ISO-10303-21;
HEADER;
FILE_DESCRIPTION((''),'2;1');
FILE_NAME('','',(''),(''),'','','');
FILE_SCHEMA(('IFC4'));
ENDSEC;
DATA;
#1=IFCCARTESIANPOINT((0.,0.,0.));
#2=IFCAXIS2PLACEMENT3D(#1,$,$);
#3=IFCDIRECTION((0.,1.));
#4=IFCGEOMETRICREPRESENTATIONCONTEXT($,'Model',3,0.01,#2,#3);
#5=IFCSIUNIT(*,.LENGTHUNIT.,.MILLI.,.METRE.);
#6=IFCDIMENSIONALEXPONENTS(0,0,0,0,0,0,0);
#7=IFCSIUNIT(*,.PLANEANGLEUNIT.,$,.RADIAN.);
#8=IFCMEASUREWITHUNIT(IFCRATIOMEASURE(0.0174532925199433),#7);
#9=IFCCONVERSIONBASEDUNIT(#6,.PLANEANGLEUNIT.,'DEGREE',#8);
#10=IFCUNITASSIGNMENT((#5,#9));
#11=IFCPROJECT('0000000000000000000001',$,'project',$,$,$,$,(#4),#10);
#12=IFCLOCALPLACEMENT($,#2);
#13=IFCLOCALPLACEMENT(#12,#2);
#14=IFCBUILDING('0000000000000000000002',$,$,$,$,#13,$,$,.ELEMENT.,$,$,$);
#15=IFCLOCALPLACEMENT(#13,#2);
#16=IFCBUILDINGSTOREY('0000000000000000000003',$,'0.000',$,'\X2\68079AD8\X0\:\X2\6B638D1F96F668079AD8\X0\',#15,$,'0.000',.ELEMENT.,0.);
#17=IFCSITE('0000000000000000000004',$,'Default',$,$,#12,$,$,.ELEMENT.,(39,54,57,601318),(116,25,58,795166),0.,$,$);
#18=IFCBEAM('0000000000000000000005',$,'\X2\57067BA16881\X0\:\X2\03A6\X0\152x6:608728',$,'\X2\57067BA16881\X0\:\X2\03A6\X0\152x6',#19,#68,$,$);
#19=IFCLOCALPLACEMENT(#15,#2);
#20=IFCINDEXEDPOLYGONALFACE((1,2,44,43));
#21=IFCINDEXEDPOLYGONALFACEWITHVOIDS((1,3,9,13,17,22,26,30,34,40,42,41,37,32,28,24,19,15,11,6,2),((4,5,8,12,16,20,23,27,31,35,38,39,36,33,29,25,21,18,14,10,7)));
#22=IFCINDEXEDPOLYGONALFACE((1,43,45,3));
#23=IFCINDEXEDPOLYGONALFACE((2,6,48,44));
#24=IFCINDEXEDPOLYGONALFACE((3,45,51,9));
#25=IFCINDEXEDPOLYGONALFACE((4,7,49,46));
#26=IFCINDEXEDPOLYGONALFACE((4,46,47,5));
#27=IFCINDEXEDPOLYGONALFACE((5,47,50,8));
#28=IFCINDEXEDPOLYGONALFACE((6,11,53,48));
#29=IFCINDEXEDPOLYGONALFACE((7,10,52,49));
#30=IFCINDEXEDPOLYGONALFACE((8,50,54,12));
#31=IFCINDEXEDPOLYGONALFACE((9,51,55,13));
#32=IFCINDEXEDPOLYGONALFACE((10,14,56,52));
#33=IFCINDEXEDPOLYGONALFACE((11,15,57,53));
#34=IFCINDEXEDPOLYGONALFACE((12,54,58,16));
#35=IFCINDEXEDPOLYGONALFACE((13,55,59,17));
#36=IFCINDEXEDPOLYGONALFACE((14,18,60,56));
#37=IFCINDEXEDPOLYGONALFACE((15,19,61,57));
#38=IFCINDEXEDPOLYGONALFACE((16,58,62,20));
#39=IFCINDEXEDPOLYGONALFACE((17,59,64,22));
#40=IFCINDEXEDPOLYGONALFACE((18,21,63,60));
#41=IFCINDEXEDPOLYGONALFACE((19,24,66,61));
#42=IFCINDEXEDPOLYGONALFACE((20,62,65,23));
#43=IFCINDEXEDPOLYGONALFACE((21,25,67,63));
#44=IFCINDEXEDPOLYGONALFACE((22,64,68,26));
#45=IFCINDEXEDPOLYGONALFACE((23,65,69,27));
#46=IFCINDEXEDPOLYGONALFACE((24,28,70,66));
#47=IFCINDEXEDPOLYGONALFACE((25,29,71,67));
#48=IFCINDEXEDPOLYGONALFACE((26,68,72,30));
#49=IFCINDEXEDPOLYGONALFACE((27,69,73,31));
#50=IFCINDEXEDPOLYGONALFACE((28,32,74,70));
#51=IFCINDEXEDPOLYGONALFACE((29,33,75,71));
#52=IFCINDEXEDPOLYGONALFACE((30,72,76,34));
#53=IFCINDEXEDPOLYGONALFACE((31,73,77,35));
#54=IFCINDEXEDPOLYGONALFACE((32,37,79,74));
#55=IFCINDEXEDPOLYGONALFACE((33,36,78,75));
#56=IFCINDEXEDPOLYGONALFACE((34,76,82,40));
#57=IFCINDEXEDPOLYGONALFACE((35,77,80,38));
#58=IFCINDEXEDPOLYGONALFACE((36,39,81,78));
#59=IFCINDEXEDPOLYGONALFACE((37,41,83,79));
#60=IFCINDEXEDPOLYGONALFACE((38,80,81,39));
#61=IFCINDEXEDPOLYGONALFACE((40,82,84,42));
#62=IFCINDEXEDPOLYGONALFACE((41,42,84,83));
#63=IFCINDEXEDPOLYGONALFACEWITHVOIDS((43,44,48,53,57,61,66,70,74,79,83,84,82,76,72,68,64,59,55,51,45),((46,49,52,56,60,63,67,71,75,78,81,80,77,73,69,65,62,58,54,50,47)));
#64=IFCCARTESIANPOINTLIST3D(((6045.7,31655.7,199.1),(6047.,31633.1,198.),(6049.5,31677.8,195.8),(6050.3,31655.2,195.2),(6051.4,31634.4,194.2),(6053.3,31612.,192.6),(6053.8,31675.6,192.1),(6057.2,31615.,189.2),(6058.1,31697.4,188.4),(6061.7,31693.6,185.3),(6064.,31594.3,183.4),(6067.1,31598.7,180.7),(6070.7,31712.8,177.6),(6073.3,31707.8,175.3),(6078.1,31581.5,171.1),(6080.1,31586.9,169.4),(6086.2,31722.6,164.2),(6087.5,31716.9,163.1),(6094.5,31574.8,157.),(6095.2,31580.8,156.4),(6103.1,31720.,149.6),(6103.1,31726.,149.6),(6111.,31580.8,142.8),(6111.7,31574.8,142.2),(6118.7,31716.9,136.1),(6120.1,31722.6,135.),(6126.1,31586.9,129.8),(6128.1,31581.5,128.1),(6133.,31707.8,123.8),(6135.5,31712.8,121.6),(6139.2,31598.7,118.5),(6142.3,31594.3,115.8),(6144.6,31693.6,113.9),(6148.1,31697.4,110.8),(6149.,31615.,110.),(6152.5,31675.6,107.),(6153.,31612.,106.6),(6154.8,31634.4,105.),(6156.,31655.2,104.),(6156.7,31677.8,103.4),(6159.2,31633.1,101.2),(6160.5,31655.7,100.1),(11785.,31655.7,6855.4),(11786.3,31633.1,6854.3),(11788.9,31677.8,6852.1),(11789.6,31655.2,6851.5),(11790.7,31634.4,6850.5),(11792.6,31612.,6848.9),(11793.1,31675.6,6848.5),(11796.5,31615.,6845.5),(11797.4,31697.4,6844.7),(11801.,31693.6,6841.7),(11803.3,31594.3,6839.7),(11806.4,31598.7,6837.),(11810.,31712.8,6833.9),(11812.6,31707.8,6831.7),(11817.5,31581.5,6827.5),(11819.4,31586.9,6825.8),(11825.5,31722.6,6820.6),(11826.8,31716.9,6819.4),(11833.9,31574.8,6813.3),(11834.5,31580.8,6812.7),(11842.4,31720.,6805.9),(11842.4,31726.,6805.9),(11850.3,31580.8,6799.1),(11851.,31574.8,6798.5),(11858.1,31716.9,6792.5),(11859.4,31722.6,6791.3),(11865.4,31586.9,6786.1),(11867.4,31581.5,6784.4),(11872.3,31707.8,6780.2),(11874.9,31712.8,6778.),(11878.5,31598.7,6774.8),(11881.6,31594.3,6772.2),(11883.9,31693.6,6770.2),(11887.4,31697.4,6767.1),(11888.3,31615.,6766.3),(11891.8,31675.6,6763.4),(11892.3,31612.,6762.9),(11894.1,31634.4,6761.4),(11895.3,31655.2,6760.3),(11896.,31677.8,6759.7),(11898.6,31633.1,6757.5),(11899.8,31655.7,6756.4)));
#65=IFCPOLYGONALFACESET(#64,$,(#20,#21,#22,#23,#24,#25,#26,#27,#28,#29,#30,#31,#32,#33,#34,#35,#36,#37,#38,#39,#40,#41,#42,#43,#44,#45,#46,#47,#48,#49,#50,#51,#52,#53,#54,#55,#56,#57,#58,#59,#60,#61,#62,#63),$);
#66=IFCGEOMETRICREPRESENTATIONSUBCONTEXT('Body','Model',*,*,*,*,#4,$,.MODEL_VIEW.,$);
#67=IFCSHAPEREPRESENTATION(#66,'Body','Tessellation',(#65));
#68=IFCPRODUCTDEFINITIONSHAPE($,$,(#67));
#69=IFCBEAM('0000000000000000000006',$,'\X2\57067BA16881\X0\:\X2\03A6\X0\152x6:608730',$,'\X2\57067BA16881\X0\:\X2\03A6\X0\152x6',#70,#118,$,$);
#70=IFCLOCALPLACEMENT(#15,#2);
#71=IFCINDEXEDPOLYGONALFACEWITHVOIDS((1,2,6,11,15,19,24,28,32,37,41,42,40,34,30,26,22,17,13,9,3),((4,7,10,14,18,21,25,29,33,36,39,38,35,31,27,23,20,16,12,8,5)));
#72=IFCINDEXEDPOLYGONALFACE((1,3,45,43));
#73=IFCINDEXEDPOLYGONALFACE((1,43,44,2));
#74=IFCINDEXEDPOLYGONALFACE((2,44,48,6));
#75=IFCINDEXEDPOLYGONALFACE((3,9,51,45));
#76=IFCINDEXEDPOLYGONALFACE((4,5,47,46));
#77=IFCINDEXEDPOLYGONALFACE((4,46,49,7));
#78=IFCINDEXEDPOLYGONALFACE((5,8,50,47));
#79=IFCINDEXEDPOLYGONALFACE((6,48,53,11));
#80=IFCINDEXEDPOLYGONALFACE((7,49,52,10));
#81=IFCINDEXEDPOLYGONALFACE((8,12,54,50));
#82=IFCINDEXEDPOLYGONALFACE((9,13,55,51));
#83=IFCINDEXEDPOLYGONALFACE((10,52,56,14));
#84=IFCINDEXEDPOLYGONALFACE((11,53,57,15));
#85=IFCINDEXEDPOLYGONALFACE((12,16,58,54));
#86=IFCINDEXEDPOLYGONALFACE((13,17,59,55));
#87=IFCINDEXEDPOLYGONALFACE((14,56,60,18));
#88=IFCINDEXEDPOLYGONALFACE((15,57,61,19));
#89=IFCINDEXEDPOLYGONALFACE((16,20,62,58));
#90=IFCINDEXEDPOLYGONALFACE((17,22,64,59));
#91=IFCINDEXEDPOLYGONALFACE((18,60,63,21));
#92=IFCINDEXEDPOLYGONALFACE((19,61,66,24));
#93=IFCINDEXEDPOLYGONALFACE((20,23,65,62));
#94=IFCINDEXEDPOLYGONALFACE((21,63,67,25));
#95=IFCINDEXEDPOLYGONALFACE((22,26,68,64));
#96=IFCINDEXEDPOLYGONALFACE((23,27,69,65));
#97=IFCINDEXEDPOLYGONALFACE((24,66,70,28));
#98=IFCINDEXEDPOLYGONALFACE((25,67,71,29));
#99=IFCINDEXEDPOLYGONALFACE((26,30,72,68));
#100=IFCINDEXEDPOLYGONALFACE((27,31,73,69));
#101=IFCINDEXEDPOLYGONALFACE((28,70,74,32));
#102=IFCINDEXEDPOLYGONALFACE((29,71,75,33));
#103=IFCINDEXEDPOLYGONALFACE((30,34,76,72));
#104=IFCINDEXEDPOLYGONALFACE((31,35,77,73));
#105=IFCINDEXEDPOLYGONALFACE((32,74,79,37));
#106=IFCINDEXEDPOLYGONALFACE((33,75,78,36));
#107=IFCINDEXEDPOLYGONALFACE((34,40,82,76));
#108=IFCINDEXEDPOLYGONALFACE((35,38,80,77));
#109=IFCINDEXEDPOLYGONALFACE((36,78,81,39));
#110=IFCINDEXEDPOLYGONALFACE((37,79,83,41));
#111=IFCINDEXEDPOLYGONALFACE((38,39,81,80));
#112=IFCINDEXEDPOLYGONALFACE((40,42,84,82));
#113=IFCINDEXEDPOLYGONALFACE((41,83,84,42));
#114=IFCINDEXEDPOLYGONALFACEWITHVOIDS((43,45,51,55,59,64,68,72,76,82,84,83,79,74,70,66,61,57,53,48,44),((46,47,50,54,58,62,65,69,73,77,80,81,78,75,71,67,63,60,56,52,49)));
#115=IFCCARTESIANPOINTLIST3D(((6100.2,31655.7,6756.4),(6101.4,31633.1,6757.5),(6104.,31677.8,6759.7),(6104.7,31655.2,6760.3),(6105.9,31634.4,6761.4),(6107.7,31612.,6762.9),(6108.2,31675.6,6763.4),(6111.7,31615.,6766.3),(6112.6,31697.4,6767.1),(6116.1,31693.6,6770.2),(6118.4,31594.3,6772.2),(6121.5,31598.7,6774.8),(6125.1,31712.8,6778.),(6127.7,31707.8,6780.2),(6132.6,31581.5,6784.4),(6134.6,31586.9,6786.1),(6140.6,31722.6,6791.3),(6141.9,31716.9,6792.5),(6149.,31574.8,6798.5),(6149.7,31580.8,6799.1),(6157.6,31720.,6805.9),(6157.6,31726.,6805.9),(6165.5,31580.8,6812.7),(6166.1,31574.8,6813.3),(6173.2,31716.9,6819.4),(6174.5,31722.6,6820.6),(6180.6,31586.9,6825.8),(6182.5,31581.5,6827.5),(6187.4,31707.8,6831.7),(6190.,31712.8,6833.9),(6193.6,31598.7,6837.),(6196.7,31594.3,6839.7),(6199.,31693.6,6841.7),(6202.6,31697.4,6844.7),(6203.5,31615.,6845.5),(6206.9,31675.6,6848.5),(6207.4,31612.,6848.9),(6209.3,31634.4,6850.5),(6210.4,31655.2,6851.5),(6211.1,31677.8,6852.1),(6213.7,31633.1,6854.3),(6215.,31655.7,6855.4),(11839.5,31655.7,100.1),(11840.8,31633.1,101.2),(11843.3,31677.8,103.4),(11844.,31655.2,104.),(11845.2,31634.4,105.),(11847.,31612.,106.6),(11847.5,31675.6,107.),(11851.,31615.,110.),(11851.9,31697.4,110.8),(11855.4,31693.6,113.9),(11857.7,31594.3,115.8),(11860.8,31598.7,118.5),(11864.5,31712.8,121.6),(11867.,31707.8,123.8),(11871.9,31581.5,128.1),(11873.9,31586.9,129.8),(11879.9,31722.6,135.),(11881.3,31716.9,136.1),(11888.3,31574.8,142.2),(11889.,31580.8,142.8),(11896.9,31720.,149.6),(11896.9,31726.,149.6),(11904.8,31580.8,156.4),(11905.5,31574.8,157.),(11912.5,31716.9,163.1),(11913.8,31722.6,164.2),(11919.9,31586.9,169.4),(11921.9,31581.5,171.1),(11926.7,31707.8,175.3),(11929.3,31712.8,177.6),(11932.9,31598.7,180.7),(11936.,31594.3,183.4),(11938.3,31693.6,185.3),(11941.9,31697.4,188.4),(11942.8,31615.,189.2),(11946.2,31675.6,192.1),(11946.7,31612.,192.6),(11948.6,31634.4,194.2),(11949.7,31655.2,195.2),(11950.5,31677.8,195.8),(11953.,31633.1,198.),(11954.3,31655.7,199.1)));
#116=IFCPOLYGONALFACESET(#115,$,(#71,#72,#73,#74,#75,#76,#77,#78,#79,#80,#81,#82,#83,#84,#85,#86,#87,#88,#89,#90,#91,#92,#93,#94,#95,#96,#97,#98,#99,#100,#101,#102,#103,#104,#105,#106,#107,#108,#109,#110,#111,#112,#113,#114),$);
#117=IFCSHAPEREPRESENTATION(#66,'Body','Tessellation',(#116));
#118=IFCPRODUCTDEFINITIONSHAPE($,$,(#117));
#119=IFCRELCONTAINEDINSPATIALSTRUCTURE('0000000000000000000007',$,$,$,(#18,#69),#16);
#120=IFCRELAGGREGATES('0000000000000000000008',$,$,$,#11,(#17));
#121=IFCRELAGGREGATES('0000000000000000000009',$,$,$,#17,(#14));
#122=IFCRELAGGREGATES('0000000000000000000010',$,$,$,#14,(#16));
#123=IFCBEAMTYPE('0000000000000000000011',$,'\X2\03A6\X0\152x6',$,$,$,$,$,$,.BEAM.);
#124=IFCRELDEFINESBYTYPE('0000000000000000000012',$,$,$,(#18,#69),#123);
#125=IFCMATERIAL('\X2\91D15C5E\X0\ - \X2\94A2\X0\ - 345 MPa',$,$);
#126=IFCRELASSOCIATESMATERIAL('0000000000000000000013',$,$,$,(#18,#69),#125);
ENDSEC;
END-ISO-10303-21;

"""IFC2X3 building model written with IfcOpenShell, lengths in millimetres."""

from ifc_helpers import new_model, entity, si_unit, converted_unit, direction, frame, frame_2d, origin, place, context, subcontext, project, spatial, hollow_circle, extrude, material, type_object, element, save


model = new_model("IFC2X3")

# Units and contexts
model_context = context("Model", 3, precision=0.01, world=origin(), true_north=direction((0.0, 1.0)))
body_context = subcontext(model_context, "Body", "Model", "MODEL_VIEW")
ifc_project = project(units=[si_unit("LENGTHUNIT", "METRE", prefix="MILLI"), converted_unit("PLANEANGLEUNIT", "DEGREE", entity("IfcRatioMeasure", 0.0174532925199433), si_unit("PLANEANGLEUNIT", "RADIAN"), dimensions=[0, 0, 0, 0, 0, 0, 0])], contexts=[model_context])

# Site, building, storey
site_placement = place(None, origin())
site = spatial("IfcSite", under=ifc_project, at=site_placement, Name="Default", CompositionType="ELEMENT", RefLatitude=(39, 54, 57, 601318), RefLongitude=(116, 25, 58, 795166), RefElevation=0.0)
building_placement = place(site_placement, origin())
building = spatial("IfcBuilding", under=site, at=building_placement, CompositionType="ELEMENT")
storey_placement = place(building_placement, origin())
storey = spatial("IfcBuildingStorey", under=building, at=storey_placement, Name="0.000", ObjectType="标高:正负零标高", LongName="0.000", CompositionType="ELEMENT", Elevation=0.0)

# Shared definitions
ifc_material_1 = material(Name="金属 - 钢 - 345 MPa")

# Beams
beam_type_1 = type_object("IfcBeamType", Name="Φ152x6", PredefinedType="BEAM")
beam_1_placement = place(storey_placement, frame((6138.2, 31650.0, -116.0), z_axis=(0.757348, 0.0, -0.653011), x_axis=(0.653011, 0.0, 0.757348)))
element("IfcBeam", 1, at=beam_1_placement, inside=storey, type_object=beam_type_1, material=ifc_material_1, Name="圆管梁:Φ152x6:608728", ObjectType="圆管梁:Φ152x6", context=body_context, shape_type="SweptSolid", body=[
    extrude(hollow_circle(Radius=76.0, WallThickness=6.0, at=frame_2d((0.0, 0.0), x_axis=(1.0, 0.0))), frame((178.3, 0.0, -200.0), z_axis=(1.0, 0.0, 0.0), x_axis=(0.0, -1.0, 0.0)), (0.0, 0.0, 1.0), 8789.0),
])
beam_2_placement = place(storey_placement, frame((11861.8, 31650.0, -116.0), z_axis=(0.757348, 0.0, 0.653011), x_axis=(-0.653011, 0.0, 0.757348)))
element("IfcBeam", 2, at=beam_2_placement, inside=storey, type_object=beam_type_1, material=ifc_material_1, Name="圆管梁:Φ152x6:608730", ObjectType="圆管梁:Φ152x6", context=body_context, shape_type="SweptSolid", body=[
    extrude(hollow_circle(Radius=76.0, WallThickness=6.0, at=frame_2d((0.0, 0.0), x_axis=(1.0, 0.0))), frame((178.3, 0.0, 200.0), z_axis=(1.0, 0.0, 0.0), x_axis=(0.0, -1.0, 0.0)), (0.0, 0.0, 1.0), 8789.0),
])

save(model, "model.ifc")
